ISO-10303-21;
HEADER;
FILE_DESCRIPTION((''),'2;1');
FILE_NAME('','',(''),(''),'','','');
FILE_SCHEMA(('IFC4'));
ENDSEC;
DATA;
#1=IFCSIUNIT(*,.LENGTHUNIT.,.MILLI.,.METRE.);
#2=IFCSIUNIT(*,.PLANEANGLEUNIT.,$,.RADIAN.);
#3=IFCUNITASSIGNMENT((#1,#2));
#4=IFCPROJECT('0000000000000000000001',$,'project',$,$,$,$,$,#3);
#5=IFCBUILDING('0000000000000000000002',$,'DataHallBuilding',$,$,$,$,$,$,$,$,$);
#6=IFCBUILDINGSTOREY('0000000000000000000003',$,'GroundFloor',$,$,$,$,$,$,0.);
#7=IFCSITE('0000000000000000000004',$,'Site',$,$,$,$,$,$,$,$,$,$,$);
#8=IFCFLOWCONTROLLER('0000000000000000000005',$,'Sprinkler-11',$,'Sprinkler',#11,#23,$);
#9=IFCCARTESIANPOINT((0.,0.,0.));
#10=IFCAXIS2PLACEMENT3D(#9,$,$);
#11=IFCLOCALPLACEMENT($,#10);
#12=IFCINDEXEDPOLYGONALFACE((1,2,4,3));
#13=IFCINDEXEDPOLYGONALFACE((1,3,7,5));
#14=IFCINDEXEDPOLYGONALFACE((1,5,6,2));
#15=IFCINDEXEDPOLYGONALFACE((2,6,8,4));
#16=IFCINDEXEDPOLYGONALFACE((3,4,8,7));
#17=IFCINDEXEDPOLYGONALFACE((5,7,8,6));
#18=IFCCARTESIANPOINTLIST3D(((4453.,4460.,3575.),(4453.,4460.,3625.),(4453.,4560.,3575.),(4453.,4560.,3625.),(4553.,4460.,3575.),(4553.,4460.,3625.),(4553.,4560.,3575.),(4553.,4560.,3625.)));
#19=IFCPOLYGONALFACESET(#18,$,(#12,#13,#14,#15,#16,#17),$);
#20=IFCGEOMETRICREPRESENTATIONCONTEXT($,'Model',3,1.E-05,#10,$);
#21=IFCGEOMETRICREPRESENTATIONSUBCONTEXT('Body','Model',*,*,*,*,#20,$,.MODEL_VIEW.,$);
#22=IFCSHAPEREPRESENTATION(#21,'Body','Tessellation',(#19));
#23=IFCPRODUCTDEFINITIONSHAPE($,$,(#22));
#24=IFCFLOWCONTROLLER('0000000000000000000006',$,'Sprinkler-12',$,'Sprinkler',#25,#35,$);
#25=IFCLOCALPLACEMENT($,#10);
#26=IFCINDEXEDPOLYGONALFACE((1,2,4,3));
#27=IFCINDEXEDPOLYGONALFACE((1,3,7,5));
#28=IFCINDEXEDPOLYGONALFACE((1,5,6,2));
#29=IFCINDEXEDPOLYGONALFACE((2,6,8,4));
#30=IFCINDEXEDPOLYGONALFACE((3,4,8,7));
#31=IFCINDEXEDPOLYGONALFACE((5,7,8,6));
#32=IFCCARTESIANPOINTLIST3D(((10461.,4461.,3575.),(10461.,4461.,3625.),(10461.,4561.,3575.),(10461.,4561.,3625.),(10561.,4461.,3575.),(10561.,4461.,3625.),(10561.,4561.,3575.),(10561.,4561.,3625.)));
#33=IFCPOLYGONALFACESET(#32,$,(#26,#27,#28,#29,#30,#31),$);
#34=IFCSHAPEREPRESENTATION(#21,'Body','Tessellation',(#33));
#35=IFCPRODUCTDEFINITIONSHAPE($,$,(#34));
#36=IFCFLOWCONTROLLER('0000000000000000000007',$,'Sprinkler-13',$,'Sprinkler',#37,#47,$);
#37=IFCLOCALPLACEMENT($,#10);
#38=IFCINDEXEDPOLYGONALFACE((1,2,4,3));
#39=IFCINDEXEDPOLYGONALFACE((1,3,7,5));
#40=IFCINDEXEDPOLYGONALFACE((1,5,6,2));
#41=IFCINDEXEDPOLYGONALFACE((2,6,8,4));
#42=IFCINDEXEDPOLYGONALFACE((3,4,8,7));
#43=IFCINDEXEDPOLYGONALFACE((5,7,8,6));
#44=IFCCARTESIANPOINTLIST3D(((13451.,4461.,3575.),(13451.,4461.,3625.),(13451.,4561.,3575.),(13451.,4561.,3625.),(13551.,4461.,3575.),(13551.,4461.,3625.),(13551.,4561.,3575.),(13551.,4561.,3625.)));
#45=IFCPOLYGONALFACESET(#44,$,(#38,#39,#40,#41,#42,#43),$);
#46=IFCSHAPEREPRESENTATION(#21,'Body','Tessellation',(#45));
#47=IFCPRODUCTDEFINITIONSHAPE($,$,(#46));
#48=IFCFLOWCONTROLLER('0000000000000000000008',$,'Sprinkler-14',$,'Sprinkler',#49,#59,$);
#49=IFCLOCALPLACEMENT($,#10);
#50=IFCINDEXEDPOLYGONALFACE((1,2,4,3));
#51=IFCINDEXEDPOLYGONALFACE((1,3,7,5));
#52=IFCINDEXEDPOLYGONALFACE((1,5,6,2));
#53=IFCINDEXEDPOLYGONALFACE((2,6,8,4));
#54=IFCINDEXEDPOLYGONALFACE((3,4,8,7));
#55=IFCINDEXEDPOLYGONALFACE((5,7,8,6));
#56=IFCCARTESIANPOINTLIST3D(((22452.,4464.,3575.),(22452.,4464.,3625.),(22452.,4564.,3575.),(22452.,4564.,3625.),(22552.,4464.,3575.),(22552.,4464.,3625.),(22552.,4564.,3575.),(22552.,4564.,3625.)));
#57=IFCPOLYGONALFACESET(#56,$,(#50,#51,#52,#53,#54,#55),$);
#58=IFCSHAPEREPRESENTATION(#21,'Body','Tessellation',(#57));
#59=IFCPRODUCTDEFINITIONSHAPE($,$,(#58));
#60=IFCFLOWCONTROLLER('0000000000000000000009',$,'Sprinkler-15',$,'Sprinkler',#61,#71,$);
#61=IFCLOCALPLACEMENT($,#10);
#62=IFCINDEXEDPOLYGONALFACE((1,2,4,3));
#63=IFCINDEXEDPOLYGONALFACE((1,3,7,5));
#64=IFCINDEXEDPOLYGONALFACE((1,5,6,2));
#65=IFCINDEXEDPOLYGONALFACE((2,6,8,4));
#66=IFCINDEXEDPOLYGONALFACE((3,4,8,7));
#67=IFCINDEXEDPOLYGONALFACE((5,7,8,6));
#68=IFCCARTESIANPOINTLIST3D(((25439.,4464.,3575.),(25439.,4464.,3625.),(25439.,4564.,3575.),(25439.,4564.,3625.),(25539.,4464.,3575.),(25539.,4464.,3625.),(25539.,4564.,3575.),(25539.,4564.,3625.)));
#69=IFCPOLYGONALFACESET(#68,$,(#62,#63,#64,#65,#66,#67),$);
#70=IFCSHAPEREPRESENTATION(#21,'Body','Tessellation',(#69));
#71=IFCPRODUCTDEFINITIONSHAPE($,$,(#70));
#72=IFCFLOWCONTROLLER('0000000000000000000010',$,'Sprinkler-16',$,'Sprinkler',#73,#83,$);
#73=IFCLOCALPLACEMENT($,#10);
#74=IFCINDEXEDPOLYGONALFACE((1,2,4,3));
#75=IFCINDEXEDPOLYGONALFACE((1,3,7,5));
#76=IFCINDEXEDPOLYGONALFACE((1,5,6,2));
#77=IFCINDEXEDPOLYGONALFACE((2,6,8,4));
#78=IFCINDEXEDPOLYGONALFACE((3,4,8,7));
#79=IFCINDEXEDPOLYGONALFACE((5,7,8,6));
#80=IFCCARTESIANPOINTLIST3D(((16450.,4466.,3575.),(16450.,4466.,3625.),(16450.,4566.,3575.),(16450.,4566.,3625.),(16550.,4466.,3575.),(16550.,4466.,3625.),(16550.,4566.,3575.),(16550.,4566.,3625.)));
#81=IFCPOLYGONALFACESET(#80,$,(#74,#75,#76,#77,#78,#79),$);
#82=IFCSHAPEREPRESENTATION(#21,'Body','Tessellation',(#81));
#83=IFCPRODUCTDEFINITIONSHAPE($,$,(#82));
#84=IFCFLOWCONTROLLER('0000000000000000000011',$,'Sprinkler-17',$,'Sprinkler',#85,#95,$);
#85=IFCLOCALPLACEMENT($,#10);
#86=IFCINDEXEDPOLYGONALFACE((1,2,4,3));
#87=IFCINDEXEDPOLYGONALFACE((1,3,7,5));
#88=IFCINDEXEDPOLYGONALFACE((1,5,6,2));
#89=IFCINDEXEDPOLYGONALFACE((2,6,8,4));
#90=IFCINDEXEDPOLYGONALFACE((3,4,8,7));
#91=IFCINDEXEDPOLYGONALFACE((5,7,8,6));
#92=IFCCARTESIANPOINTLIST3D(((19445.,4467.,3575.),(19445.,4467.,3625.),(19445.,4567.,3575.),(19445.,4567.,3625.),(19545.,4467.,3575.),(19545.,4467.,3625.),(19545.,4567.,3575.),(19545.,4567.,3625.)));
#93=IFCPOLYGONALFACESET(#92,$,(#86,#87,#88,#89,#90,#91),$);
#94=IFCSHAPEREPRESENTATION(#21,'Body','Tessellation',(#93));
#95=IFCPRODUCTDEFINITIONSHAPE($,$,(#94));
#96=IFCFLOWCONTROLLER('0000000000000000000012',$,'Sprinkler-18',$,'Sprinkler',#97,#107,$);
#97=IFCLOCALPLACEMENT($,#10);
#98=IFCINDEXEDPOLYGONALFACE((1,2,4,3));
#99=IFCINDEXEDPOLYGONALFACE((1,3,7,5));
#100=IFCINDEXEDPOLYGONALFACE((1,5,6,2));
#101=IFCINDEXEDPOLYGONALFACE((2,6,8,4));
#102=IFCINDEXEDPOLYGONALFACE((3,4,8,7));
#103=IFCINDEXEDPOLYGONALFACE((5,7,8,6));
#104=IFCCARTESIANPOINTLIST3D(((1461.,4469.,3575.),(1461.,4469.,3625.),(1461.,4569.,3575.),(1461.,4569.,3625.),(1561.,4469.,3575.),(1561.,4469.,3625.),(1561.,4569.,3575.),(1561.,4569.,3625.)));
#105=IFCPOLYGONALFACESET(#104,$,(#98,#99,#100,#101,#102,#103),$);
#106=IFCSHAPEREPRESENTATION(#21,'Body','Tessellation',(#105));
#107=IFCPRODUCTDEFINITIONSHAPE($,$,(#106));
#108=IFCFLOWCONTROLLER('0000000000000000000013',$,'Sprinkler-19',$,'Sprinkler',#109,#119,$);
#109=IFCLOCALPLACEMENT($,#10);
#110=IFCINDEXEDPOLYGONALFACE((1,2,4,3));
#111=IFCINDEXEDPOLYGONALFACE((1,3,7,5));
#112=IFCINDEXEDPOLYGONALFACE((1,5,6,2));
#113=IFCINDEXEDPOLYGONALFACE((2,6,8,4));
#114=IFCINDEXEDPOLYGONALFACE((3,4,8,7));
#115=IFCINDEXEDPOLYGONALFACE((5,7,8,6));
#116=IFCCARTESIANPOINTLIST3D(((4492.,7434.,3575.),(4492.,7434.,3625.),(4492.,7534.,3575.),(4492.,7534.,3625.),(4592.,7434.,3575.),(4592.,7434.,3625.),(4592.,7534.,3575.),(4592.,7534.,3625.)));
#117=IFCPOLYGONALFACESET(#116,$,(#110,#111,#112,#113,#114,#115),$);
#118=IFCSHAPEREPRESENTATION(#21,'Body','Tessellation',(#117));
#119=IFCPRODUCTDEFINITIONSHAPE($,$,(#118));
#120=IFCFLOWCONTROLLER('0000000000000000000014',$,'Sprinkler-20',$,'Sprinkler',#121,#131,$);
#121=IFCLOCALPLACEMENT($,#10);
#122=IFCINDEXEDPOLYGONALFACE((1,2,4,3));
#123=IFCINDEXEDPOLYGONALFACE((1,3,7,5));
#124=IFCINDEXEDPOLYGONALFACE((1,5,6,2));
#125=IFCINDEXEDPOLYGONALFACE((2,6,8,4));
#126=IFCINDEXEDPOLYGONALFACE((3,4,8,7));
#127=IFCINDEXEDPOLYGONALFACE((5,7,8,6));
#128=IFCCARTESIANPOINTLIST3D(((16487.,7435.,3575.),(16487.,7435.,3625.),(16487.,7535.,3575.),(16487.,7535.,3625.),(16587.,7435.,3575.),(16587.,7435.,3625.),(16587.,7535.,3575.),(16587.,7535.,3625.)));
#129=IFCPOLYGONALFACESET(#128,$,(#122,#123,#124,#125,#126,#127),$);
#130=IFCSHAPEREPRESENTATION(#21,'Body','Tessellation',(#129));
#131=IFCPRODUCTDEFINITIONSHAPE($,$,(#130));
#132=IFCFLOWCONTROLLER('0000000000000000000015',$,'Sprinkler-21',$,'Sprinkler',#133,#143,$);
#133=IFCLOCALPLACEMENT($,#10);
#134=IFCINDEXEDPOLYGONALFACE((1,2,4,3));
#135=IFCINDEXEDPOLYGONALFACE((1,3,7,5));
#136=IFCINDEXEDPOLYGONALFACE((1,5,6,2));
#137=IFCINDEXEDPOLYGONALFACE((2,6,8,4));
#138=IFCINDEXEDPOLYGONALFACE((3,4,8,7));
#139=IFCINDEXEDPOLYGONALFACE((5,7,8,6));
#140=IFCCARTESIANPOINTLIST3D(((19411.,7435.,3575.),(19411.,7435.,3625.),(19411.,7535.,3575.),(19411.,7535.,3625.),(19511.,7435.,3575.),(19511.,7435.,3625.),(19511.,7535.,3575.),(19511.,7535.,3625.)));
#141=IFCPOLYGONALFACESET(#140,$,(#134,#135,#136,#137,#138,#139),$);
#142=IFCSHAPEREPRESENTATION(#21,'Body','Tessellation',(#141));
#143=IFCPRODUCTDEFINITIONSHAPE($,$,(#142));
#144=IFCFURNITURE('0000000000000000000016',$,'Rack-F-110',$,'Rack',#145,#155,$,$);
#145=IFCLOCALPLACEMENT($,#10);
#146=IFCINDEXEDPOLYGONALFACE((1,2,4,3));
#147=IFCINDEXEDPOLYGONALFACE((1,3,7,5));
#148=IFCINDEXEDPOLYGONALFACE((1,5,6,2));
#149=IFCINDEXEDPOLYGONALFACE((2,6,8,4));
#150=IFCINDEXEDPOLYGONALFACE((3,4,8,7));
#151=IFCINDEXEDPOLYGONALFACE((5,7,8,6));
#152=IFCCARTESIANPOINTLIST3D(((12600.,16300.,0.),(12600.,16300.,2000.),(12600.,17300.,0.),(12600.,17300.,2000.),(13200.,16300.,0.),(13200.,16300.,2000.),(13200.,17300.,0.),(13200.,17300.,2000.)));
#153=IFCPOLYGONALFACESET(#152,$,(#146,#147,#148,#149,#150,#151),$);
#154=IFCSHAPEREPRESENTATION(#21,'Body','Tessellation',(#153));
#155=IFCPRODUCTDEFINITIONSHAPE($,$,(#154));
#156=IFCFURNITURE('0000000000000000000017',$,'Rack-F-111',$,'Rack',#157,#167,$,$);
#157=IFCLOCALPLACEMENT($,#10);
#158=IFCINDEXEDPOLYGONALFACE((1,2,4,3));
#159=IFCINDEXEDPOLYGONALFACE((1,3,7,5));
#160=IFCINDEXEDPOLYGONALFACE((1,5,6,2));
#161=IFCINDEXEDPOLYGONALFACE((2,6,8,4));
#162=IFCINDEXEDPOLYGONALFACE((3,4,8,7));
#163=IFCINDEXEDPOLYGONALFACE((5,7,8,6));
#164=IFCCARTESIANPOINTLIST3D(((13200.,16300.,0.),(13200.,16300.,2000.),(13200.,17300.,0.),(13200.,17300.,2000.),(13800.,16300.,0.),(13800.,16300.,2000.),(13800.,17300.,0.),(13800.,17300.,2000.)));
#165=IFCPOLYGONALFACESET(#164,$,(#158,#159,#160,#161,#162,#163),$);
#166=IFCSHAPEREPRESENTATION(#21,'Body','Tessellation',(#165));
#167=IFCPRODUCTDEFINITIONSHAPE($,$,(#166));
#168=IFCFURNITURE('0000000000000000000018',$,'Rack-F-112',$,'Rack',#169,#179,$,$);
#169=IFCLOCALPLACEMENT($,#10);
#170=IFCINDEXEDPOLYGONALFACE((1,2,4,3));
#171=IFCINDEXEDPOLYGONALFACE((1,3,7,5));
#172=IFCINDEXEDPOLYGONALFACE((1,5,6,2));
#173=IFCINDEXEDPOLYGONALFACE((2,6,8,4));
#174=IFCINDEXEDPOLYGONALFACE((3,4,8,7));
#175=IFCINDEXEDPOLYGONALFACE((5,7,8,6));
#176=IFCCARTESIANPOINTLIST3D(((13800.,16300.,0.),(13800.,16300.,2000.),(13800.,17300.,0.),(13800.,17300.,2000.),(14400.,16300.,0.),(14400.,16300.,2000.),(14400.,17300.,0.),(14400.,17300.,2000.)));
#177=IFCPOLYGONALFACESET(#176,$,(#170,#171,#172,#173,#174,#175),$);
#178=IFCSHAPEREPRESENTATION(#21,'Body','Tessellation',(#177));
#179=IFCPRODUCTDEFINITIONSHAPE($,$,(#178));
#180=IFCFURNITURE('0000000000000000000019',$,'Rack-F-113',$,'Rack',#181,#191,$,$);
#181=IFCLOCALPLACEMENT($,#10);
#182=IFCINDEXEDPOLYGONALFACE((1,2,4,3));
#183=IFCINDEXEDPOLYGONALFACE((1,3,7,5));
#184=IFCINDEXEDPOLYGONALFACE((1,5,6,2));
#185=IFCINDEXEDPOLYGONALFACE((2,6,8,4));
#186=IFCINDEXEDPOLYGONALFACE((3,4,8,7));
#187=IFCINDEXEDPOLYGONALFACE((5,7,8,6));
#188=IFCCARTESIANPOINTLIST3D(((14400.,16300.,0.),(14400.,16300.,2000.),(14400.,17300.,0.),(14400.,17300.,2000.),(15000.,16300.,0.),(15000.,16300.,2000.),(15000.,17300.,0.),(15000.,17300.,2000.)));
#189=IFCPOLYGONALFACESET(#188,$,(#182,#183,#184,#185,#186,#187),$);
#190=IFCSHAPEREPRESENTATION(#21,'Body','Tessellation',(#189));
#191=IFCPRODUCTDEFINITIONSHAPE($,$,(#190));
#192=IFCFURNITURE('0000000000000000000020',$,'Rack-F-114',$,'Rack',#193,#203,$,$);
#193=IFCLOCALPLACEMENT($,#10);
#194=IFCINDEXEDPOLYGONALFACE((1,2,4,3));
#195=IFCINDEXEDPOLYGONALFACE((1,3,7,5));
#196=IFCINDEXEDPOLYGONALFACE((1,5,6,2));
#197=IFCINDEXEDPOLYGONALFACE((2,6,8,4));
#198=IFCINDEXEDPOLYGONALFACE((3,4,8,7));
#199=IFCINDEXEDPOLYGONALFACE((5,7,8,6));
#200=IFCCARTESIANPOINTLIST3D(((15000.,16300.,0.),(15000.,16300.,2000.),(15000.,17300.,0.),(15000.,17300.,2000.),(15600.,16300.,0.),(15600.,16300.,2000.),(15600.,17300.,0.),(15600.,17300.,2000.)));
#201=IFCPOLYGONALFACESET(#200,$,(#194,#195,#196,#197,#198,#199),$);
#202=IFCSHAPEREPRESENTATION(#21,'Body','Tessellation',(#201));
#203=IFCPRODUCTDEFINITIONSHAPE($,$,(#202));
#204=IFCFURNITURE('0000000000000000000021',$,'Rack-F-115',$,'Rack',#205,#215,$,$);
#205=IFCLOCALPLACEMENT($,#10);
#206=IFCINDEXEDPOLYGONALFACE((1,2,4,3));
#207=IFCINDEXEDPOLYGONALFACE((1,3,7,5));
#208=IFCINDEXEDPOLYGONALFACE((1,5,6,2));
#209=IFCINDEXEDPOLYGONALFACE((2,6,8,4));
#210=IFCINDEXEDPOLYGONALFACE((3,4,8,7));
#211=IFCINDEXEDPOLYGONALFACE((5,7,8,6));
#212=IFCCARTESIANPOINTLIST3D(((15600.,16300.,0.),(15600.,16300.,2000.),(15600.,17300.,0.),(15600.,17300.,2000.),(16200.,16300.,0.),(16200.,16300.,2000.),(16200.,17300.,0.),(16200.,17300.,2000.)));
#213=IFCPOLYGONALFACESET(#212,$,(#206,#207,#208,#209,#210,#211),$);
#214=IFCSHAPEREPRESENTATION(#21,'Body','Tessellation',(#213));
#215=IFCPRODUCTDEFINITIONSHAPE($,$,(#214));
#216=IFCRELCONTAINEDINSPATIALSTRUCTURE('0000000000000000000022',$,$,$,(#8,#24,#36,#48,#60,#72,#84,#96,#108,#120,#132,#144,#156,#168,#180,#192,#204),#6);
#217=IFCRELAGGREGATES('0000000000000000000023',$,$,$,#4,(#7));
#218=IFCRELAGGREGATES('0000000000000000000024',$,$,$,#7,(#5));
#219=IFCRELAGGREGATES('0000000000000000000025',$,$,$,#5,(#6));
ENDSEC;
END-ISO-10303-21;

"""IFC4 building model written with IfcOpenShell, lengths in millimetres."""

from ifc_helpers import new_model, si_unit, frame, origin, place, context, subcontext, project, spatial, rectangle, extrude, element, save


model = new_model("IFC4")

# Units and contexts
model_context = context("Model", 3, precision=1e-05, world=origin())
body_context = subcontext(model_context, "Body", "Model", "MODEL_VIEW")
ifc_project = project(units=[si_unit("LENGTHUNIT", "METRE", prefix="MILLI"), si_unit("PLANEANGLEUNIT", "RADIAN")])

# Site, building, storey
site = spatial("IfcSite", under=ifc_project, Name="Site")
building = spatial("IfcBuilding", under=site, Name="DataHallBuilding")
storey = spatial("IfcBuildingStorey", under=building, Name="GroundFloor", Elevation=0.0)

# Flow controllers
flow_controller_1_placement = place(None, origin())
element("IfcFlowController", 1, at=flow_controller_1_placement, inside=storey, Name="Sprinkler-11", ObjectType="Sprinkler", context=body_context, shape_type="SweptSolid", body=[
    extrude(rectangle(XDim=100.0, YDim=100.0), frame((4503.0, 4510.0, 3575.0), z_axis=(0.0, 0.0, 1.0), x_axis=(1.0, 0.0, 0.0)), (0.0, 0.0, 1.0), 50.0),
])
flow_controller_2_placement = place(None, origin())
element("IfcFlowController", 2, at=flow_controller_2_placement, inside=storey, Name="Sprinkler-12", ObjectType="Sprinkler", context=body_context, shape_type="SweptSolid", body=[
    extrude(rectangle(XDim=100.0, YDim=100.0), frame((10511.0, 4511.0, 3575.0), z_axis=(0.0, 0.0, 1.0), x_axis=(1.0, 0.0, 0.0)), (0.0, 0.0, 1.0), 50.0),
])
flow_controller_3_placement = place(None, origin())
element("IfcFlowController", 3, at=flow_controller_3_placement, inside=storey, Name="Sprinkler-13", ObjectType="Sprinkler", context=body_context, shape_type="SweptSolid", body=[
    extrude(rectangle(XDim=100.0, YDim=100.0), frame((13501.0, 4511.0, 3575.0), z_axis=(0.0, 0.0, 1.0), x_axis=(1.0, 0.0, 0.0)), (0.0, 0.0, 1.0), 50.0),
])
flow_controller_4_placement = place(None, origin())
element("IfcFlowController", 4, at=flow_controller_4_placement, inside=storey, Name="Sprinkler-14", ObjectType="Sprinkler", context=body_context, shape_type="SweptSolid", body=[
    extrude(rectangle(XDim=100.0, YDim=100.0), frame((22502.0, 4514.0, 3575.0), z_axis=(0.0, 0.0, 1.0), x_axis=(1.0, 0.0, 0.0)), (0.0, 0.0, 1.0), 50.0),
])
flow_controller_5_placement = place(None, origin())
element("IfcFlowController", 5, at=flow_controller_5_placement, inside=storey, Name="Sprinkler-15", ObjectType="Sprinkler", context=body_context, shape_type="SweptSolid", body=[
    extrude(rectangle(XDim=100.0, YDim=100.0), frame((25489.0, 4514.0, 3575.0), z_axis=(0.0, 0.0, 1.0), x_axis=(1.0, 0.0, 0.0)), (0.0, 0.0, 1.0), 50.0),
])
flow_controller_6_placement = place(None, origin())
element("IfcFlowController", 6, at=flow_controller_6_placement, inside=storey, Name="Sprinkler-16", ObjectType="Sprinkler", context=body_context, shape_type="SweptSolid", body=[
    extrude(rectangle(XDim=100.0, YDim=100.0), frame((16500.0, 4516.0, 3575.0), z_axis=(0.0, 0.0, 1.0), x_axis=(1.0, 0.0, 0.0)), (0.0, 0.0, 1.0), 50.0),
])
flow_controller_7_placement = place(None, origin())
element("IfcFlowController", 7, at=flow_controller_7_placement, inside=storey, Name="Sprinkler-17", ObjectType="Sprinkler", context=body_context, shape_type="SweptSolid", body=[
    extrude(rectangle(XDim=100.0, YDim=100.0), frame((19495.0, 4517.0, 3575.0), z_axis=(0.0, 0.0, 1.0), x_axis=(1.0, 0.0, 0.0)), (0.0, 0.0, 1.0), 50.0),
])
flow_controller_8_placement = place(None, origin())
element("IfcFlowController", 8, at=flow_controller_8_placement, inside=storey, Name="Sprinkler-18", ObjectType="Sprinkler", context=body_context, shape_type="SweptSolid", body=[
    extrude(rectangle(XDim=100.0, YDim=100.0), frame((1511.0, 4519.0, 3575.0), z_axis=(0.0, 0.0, 1.0), x_axis=(1.0, 0.0, 0.0)), (0.0, 0.0, 1.0), 50.0),
])
flow_controller_9_placement = place(None, origin())
element("IfcFlowController", 9, at=flow_controller_9_placement, inside=storey, Name="Sprinkler-19", ObjectType="Sprinkler", context=body_context, shape_type="SweptSolid", body=[
    extrude(rectangle(XDim=100.0, YDim=100.0), frame((4542.0, 7484.0, 3575.0), z_axis=(0.0, 0.0, 1.0), x_axis=(1.0, 0.0, 0.0)), (0.0, 0.0, 1.0), 50.0),
])
flow_controller_10_placement = place(None, origin())
element("IfcFlowController", 10, at=flow_controller_10_placement, inside=storey, Name="Sprinkler-20", ObjectType="Sprinkler", context=body_context, shape_type="SweptSolid", body=[
    extrude(rectangle(XDim=100.0, YDim=100.0), frame((16537.0, 7485.0, 3575.0), z_axis=(0.0, 0.0, 1.0), x_axis=(1.0, 0.0, 0.0)), (0.0, 0.0, 1.0), 50.0),
])
flow_controller_11_placement = place(None, origin())
element("IfcFlowController", 11, at=flow_controller_11_placement, inside=storey, Name="Sprinkler-21", ObjectType="Sprinkler", context=body_context, shape_type="SweptSolid", body=[
    extrude(rectangle(XDim=100.0, YDim=100.0), frame((19461.0, 7485.0, 3575.0), z_axis=(0.0, 0.0, 1.0), x_axis=(1.0, 0.0, 0.0)), (0.0, 0.0, 1.0), 50.0),
])

# Furniture
furniture_1_placement = place(None, origin())
element("IfcFurniture", 12, at=furniture_1_placement, inside=storey, Name="Rack-F-110", ObjectType="Rack", context=body_context, shape_type="SweptSolid", body=[
    extrude(rectangle(XDim=600.0, YDim=1000.0), frame((12900.0, 16800.0, 0.0), z_axis=(0.0, 0.0, 1.0), x_axis=(1.0, 0.0, 0.0)), (0.0, 0.0, 1.0), 2000.0),
])
furniture_2_placement = place(None, origin())
element("IfcFurniture", 13, at=furniture_2_placement, inside=storey, Name="Rack-F-111", ObjectType="Rack", context=body_context, shape_type="SweptSolid", body=[
    extrude(rectangle(XDim=600.0, YDim=1000.0), frame((13500.0, 16800.0, 0.0), z_axis=(0.0, 0.0, 1.0), x_axis=(1.0, 0.0, 0.0)), (0.0, 0.0, 1.0), 2000.0),
])
furniture_3_placement = place(None, origin())
element("IfcFurniture", 14, at=furniture_3_placement, inside=storey, Name="Rack-F-112", ObjectType="Rack", context=body_context, shape_type="SweptSolid", body=[
    extrude(rectangle(XDim=600.0, YDim=1000.0), frame((14100.0, 16800.0, 0.0), z_axis=(0.0, 0.0, 1.0), x_axis=(1.0, 0.0, 0.0)), (0.0, 0.0, 1.0), 2000.0),
])
furniture_4_placement = place(None, origin())
element("IfcFurniture", 15, at=furniture_4_placement, inside=storey, Name="Rack-F-113", ObjectType="Rack", context=body_context, shape_type="SweptSolid", body=[
    extrude(rectangle(XDim=600.0, YDim=1000.0), frame((14700.0, 16800.0, 0.0), z_axis=(0.0, 0.0, 1.0), x_axis=(1.0, 0.0, 0.0)), (0.0, 0.0, 1.0), 2000.0),
])
furniture_5_placement = place(None, origin())
element("IfcFurniture", 16, at=furniture_5_placement, inside=storey, Name="Rack-F-114", ObjectType="Rack", context=body_context, shape_type="SweptSolid", body=[
    extrude(rectangle(XDim=600.0, YDim=1000.0), frame((15300.0, 16800.0, 0.0), z_axis=(0.0, 0.0, 1.0), x_axis=(1.0, 0.0, 0.0)), (0.0, 0.0, 1.0), 2000.0),
])
furniture_6_placement = place(None, origin())
element("IfcFurniture", 17, at=furniture_6_placement, inside=storey, Name="Rack-F-115", ObjectType="Rack", context=body_context, shape_type="SweptSolid", body=[
    extrude(rectangle(XDim=600.0, YDim=1000.0), frame((15900.0, 16800.0, 0.0), z_axis=(0.0, 0.0, 1.0), x_axis=(1.0, 0.0, 0.0)), (0.0, 0.0, 1.0), 2000.0),
])

save(model, "model.ifc")
